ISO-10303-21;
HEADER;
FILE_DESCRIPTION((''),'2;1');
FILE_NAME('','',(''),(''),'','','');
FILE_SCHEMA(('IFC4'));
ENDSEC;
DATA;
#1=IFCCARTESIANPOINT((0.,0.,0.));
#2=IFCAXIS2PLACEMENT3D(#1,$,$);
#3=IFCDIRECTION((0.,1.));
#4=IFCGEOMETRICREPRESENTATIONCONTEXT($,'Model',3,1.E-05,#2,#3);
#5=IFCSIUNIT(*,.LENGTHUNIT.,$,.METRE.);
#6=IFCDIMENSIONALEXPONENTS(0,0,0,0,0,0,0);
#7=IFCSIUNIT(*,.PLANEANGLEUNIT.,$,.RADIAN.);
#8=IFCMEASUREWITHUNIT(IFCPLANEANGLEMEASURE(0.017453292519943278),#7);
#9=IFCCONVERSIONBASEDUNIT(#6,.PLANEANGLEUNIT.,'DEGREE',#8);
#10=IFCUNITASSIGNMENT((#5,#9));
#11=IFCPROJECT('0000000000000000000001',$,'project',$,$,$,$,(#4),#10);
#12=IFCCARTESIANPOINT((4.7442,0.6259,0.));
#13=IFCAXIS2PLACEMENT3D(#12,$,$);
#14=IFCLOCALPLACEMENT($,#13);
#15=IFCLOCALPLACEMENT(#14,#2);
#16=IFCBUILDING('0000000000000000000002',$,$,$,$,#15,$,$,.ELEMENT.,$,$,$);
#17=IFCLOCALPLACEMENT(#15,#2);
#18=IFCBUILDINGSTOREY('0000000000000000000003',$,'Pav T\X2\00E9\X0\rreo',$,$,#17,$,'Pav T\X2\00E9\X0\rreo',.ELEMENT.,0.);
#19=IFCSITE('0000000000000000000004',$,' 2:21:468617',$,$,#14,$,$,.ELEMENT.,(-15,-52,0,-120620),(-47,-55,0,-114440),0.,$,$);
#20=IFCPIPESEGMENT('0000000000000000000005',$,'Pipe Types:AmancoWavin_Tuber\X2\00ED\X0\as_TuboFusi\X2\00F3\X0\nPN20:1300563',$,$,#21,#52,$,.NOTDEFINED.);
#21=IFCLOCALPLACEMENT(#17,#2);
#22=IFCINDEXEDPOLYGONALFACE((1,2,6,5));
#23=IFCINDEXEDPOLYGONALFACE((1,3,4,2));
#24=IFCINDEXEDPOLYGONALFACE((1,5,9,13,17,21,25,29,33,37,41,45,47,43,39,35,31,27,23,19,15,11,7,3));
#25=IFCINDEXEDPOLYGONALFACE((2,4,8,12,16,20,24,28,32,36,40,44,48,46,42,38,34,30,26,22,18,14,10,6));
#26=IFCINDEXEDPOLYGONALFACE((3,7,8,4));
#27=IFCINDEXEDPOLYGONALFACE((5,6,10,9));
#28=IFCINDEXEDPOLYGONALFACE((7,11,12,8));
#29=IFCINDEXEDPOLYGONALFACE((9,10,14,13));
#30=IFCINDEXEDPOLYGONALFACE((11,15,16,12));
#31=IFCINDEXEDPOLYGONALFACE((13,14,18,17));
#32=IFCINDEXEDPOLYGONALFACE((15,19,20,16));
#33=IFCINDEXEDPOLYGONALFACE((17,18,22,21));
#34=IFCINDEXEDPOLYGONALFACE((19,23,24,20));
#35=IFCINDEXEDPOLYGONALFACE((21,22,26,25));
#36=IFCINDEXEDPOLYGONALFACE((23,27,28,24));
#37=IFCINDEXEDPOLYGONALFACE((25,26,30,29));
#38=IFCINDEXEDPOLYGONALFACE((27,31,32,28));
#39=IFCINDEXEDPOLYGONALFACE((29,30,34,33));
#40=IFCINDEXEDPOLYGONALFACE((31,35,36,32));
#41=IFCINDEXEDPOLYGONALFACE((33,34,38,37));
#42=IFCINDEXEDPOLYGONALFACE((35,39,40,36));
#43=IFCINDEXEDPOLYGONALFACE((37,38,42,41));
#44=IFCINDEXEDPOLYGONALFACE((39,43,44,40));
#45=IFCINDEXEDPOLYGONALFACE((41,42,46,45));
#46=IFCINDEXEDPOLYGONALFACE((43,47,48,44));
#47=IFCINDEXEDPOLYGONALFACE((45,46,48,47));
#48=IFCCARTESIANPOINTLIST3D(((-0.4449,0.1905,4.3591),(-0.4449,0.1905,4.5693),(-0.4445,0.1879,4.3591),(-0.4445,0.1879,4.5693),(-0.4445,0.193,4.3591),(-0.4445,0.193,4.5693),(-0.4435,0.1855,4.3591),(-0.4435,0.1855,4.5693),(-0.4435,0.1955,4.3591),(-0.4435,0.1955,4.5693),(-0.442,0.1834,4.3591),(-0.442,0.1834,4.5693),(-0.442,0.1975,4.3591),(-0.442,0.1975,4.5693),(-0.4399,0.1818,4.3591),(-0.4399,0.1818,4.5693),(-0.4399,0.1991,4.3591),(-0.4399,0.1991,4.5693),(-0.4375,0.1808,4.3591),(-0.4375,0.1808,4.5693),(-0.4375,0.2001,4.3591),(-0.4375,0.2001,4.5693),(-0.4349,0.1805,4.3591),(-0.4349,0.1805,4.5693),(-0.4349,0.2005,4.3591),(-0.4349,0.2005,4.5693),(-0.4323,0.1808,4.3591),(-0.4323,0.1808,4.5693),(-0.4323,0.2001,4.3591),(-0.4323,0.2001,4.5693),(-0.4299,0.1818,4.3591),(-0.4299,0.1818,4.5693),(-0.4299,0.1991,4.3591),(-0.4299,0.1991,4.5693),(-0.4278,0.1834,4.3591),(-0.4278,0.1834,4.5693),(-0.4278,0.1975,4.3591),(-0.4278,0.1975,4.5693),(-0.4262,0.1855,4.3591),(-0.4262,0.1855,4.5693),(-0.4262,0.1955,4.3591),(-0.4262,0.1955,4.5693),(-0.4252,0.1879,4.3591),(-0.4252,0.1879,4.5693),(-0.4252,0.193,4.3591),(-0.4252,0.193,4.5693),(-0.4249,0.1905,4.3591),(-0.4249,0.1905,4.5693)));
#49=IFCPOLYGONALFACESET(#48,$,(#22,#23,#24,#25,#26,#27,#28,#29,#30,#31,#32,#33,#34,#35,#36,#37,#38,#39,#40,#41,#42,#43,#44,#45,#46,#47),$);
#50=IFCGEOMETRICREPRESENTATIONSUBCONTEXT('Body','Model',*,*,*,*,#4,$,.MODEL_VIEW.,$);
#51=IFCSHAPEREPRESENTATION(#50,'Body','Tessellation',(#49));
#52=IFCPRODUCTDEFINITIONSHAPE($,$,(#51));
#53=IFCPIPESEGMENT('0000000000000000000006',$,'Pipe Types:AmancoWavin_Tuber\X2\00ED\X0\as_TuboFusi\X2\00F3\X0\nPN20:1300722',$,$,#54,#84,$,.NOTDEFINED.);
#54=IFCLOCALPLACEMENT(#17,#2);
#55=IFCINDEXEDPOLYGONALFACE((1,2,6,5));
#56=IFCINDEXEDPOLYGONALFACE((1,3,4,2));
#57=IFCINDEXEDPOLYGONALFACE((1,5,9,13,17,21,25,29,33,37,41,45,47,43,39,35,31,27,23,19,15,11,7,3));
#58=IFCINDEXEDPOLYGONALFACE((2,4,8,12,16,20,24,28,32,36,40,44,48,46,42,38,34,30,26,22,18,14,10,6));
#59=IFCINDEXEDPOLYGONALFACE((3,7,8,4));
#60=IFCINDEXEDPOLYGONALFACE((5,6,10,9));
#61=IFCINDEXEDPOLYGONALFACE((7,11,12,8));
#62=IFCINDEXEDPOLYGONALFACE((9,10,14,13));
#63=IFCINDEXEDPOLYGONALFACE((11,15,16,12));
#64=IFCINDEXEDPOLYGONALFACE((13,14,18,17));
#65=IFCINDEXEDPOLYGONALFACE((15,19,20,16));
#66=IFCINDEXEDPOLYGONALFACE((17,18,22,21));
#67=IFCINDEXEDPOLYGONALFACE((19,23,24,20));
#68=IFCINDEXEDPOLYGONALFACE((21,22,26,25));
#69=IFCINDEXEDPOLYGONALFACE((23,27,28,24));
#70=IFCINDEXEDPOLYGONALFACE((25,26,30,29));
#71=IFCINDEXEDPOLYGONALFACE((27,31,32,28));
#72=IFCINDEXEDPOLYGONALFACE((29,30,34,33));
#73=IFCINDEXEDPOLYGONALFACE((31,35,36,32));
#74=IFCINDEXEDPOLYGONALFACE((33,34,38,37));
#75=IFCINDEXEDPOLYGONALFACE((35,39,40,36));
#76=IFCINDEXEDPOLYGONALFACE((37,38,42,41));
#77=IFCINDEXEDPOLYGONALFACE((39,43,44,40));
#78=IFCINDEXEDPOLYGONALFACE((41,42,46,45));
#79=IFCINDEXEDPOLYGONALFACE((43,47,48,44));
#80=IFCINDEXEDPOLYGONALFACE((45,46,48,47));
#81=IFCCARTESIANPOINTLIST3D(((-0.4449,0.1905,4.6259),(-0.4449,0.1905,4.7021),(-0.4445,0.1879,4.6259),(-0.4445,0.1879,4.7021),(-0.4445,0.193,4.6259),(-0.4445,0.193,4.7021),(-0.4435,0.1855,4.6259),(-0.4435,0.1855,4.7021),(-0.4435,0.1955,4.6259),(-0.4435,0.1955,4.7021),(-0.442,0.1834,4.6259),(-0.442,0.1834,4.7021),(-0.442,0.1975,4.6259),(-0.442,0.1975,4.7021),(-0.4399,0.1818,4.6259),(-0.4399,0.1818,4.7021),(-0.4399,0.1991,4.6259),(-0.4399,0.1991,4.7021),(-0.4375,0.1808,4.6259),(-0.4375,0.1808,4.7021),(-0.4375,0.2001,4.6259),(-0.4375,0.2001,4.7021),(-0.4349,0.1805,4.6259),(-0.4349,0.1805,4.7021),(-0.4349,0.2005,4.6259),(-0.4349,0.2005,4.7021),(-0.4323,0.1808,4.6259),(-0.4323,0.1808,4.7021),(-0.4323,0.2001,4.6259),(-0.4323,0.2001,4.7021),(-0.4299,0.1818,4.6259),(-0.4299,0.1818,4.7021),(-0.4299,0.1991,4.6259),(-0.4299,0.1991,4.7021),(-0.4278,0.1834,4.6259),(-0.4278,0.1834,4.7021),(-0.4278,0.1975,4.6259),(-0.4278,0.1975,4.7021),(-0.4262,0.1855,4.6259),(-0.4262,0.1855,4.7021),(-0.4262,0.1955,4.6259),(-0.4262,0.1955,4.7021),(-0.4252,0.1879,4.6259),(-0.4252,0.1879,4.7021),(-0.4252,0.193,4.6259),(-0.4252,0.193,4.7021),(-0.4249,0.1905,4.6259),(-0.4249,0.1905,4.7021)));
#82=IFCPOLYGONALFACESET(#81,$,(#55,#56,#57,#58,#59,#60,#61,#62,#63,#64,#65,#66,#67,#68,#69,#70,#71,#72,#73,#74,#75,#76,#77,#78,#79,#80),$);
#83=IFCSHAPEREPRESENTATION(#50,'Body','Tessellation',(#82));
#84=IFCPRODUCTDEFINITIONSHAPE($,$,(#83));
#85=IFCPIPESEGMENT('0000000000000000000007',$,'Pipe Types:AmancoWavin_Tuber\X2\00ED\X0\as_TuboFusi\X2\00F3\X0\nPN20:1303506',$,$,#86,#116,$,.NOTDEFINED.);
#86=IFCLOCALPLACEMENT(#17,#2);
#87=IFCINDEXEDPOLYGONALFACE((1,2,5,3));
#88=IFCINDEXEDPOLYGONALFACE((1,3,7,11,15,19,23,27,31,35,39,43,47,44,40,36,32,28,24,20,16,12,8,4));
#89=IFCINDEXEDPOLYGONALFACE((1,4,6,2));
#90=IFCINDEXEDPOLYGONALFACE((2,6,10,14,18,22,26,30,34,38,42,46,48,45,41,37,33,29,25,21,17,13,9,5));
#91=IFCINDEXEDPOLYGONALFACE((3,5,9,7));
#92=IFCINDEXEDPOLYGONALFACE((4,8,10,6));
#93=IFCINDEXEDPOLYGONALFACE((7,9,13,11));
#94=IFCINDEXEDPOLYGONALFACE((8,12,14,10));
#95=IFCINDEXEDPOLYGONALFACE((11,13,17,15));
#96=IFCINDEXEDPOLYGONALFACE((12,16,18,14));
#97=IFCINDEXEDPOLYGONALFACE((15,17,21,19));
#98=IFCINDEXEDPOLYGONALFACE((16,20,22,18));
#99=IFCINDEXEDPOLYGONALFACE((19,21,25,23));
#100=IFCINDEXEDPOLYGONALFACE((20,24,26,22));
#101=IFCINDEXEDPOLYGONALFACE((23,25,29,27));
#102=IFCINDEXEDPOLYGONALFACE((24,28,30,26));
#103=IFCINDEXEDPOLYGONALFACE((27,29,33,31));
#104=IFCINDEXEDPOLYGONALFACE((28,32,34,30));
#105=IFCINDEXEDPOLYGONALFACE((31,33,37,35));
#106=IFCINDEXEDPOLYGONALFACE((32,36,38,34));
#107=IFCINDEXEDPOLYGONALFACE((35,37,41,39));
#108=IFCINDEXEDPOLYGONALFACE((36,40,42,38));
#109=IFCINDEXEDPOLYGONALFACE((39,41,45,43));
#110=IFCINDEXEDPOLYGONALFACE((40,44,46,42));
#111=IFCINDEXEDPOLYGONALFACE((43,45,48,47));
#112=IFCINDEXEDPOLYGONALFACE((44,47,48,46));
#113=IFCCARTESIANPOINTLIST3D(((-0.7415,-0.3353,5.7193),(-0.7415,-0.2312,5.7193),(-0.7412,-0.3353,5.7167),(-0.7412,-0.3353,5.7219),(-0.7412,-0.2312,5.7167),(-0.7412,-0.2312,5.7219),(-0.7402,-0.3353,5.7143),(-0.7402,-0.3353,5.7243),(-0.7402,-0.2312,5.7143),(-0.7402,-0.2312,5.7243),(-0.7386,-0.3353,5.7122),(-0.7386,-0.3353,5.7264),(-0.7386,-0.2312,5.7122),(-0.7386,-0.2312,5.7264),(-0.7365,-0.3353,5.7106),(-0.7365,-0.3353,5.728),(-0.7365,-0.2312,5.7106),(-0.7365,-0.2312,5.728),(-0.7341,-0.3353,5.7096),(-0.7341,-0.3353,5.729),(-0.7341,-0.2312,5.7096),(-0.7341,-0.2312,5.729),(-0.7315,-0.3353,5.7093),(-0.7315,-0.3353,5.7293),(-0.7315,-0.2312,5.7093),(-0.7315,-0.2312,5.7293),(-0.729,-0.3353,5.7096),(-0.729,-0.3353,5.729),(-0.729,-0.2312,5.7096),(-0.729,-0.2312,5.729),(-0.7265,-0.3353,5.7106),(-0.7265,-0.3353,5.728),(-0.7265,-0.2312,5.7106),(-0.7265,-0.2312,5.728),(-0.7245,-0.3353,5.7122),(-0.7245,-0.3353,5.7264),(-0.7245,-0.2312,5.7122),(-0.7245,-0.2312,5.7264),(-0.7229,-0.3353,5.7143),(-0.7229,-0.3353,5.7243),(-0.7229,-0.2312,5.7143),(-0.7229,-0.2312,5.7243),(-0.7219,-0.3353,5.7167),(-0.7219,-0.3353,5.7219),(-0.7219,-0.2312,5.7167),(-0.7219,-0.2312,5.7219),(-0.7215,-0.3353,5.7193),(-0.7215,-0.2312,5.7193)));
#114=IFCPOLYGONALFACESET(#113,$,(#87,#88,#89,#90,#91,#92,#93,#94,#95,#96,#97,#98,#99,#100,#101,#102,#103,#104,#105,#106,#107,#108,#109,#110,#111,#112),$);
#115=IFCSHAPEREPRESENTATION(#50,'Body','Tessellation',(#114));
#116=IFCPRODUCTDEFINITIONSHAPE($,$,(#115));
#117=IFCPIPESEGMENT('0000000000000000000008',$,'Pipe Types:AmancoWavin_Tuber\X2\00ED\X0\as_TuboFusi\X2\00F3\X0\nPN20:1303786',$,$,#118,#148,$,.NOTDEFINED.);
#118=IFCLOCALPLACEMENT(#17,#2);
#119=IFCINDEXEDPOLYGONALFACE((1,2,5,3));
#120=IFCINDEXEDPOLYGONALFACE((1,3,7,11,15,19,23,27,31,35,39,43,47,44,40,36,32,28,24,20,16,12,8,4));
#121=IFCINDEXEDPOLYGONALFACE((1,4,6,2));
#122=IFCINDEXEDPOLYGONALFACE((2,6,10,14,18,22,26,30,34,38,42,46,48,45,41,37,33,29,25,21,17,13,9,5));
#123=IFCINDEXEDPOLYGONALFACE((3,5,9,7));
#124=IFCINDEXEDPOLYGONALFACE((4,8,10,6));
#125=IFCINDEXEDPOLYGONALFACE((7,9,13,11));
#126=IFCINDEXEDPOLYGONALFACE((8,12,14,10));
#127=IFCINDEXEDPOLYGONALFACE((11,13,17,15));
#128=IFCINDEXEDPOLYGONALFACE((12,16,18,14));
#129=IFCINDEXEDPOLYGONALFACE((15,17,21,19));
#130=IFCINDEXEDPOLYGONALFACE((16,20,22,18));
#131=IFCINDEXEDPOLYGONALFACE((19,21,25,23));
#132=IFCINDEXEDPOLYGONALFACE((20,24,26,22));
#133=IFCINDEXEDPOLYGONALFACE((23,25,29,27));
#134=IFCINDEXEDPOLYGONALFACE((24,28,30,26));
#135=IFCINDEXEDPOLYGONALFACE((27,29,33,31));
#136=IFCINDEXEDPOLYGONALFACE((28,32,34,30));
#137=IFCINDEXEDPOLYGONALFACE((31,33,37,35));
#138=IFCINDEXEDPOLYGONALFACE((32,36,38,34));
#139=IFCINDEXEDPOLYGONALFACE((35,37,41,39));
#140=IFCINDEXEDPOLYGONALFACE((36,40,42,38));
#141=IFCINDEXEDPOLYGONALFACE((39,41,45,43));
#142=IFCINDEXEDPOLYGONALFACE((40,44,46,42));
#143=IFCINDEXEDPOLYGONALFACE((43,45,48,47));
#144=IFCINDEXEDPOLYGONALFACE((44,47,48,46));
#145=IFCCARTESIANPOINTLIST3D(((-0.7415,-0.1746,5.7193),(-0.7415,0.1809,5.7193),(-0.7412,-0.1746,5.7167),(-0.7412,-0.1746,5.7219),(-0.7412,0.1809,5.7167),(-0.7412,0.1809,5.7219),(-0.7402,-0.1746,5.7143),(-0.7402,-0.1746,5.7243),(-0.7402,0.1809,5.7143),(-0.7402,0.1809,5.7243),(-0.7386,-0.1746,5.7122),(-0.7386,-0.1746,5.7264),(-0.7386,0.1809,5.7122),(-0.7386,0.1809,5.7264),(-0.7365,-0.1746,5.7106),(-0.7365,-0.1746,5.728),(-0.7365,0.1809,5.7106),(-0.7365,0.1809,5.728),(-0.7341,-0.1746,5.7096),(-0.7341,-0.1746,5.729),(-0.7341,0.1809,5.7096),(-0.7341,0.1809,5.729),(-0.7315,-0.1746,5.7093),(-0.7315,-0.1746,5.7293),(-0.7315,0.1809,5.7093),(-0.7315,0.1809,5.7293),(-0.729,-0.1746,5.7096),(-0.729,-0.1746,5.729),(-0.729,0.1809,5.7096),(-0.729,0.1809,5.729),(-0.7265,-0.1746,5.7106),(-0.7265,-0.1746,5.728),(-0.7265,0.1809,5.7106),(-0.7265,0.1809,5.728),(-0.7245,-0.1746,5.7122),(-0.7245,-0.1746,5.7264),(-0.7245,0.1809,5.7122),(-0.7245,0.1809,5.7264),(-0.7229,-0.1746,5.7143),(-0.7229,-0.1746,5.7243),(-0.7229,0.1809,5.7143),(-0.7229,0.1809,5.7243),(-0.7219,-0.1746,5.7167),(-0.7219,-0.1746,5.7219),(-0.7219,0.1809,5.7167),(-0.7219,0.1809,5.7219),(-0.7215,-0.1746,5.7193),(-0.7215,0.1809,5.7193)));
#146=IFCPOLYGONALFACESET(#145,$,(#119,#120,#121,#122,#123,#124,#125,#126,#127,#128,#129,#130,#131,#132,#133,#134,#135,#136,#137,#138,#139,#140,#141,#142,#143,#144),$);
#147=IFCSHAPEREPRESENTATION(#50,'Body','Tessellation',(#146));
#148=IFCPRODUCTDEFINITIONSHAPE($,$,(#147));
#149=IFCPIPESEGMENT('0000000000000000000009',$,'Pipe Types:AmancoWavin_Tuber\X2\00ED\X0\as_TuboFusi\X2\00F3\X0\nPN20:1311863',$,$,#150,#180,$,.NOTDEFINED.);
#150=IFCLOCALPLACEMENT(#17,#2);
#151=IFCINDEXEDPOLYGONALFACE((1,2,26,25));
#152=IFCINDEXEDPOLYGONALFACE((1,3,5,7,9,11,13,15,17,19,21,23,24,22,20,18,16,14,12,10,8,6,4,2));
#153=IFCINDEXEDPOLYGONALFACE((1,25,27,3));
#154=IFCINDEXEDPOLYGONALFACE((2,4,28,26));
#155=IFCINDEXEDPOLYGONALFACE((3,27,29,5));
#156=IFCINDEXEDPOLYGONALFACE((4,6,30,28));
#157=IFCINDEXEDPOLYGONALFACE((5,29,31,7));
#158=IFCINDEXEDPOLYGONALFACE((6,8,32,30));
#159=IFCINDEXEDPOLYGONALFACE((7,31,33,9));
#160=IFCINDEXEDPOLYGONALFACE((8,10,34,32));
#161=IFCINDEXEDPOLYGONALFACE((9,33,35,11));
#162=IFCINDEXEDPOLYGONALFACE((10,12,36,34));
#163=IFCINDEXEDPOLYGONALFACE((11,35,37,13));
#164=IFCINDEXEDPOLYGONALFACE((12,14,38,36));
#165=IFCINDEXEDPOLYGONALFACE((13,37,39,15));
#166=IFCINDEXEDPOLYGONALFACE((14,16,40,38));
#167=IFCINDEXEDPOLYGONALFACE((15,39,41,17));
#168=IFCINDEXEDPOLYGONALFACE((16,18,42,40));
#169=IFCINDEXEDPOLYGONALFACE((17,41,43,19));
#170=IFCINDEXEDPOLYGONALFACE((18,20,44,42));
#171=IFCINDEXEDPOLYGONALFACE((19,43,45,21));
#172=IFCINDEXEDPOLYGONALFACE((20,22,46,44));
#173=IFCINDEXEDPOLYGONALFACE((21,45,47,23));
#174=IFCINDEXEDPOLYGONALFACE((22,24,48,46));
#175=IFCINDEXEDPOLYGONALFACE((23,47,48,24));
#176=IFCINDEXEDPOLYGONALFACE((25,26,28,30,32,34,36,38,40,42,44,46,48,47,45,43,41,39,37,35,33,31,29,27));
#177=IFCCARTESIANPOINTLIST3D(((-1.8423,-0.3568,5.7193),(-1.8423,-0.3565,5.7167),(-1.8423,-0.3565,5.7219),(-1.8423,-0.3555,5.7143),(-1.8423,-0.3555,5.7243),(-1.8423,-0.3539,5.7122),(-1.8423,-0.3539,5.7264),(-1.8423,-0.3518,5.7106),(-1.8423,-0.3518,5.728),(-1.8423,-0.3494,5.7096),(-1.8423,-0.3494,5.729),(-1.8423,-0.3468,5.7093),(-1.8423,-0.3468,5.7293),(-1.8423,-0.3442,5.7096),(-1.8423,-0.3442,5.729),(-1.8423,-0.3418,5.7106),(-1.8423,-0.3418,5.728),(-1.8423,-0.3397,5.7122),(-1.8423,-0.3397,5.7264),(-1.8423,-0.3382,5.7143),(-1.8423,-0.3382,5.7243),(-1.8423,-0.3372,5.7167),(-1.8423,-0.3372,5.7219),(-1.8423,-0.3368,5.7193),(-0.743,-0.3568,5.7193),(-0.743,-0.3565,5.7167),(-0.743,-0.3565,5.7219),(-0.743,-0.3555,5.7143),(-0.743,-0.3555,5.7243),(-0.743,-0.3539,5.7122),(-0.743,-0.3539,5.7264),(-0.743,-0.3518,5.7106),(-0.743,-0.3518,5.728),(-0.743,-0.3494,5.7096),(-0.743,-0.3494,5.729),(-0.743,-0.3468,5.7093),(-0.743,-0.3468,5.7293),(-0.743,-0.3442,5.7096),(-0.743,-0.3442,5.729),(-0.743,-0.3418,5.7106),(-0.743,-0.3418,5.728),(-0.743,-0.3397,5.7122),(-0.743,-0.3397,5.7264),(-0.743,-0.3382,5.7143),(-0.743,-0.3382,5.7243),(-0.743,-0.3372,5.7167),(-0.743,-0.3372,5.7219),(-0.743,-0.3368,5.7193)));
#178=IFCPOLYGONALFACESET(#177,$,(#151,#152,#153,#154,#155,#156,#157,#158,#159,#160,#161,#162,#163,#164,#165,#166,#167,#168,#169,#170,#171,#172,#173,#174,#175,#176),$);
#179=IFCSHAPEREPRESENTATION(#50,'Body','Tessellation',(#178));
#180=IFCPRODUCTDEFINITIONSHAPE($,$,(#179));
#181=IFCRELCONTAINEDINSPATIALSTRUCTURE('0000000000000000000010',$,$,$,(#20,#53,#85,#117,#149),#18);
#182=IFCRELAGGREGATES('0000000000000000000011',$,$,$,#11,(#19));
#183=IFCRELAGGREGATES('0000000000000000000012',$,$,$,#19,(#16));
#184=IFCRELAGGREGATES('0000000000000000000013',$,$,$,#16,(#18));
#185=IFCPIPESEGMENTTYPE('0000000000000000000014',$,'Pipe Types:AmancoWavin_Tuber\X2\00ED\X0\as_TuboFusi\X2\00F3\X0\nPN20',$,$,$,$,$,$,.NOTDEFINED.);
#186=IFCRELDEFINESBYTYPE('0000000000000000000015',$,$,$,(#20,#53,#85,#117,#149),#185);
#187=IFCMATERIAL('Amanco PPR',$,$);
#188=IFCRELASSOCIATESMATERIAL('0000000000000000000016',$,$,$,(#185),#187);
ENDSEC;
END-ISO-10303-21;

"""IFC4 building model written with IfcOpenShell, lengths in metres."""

from ifc_helpers import new_model, entity, si_unit, converted_unit, direction, frame, origin, place, context, subcontext, project, spatial, arc, indexed_curve, outline, extrude, material, type_object, element, save


model = new_model("IFC4")

# Units and contexts
model_context = context("Model", 3, precision=1e-05, world=origin(), true_north=direction((0.0, 1.0)))
body_context = subcontext(model_context, "Body", "Model", "MODEL_VIEW")
ifc_project = project(units=[si_unit("LENGTHUNIT", "METRE"), converted_unit("PLANEANGLEUNIT", "DEGREE", entity("IfcPlaneAngleMeasure", 0.017453292519943278), si_unit("PLANEANGLEUNIT", "RADIAN"), dimensions=[0, 0, 0, 0, 0, 0, 0])], contexts=[model_context])

# Site, building, storey
site_placement = place(None, frame((4.7442, 0.6259, 0.0)))
site = spatial("IfcSite", under=ifc_project, at=site_placement, Name=" 2:21:468617", CompositionType="ELEMENT", RefLatitude=(-15, -52, 0, -120620), RefLongitude=(-47, -55, 0, -114440), RefElevation=0.0)
building_placement = place(site_placement, origin())
building = spatial("IfcBuilding", under=site, at=building_placement, CompositionType="ELEMENT")
storey_placement = place(building_placement, origin())
storey = spatial("IfcBuildingStorey", under=building, at=storey_placement, Name="Pav Térreo", LongName="Pav Térreo", CompositionType="ELEMENT", Elevation=0.0)

# Pipe segments
ifc_material_1 = material(Name="Amanco PPR")
pipe_segment_type_1 = type_object("IfcPipeSegmentType", Name="Pipe Types:AmancoWavin_Tuberías_TuboFusiónPN20", PredefinedType="NOTDEFINED", material=ifc_material_1)
pipe_segment_1_placement = place(storey_placement, origin())
element("IfcPipeSegment", 1, at=pipe_segment_1_placement, inside=storey, type_object=pipe_segment_type_1, Name="Pipe Types:AmancoWavin_Tuberías_TuboFusiónPN20:1300563", PredefinedType="NOTDEFINED", context=body_context, shape_type="SweptSolid", body=[
    extrude(outline(indexed_curve([(0.01, 0.0), (0.0071, 0.0071), (0.0, 0.01), (-0.0071, 0.0071), (-0.01, 0.0), (-0.0071, -0.0071), (0.0, -0.01), (0.0071, -0.0071)], segments=[arc(1, 2, 3), arc(3, 4, 5), arc(5, 6, 7), arc(7, 8, 1)], self_intersect=False)), frame((-0.4349, 0.1905, 4.3591)), (0.0, 0.0, 1.0), 0.2102),
])
pipe_segment_2_placement = place(storey_placement, origin())
element("IfcPipeSegment", 2, at=pipe_segment_2_placement, inside=storey, type_object=pipe_segment_type_1, Name="Pipe Types:AmancoWavin_Tuberías_TuboFusiónPN20:1300722", PredefinedType="NOTDEFINED", context=body_context, shape_type="SweptSolid", body=[
    extrude(outline(indexed_curve([(0.01, 0.0), (0.0071, 0.0071), (0.0, 0.01), (-0.0071, 0.0071), (-0.01, 0.0), (-0.0071, -0.0071), (0.0, -0.01), (0.0071, -0.0071)], segments=[arc(1, 2, 3), arc(3, 4, 5), arc(5, 6, 7), arc(7, 8, 1)], self_intersect=False)), frame((-0.4349, 0.1905, 4.6259)), (0.0, 0.0, 1.0), 0.0762),
])
pipe_segment_3_placement = place(storey_placement, origin())
element("IfcPipeSegment", 3, at=pipe_segment_3_placement, inside=storey, type_object=pipe_segment_type_1, Name="Pipe Types:AmancoWavin_Tuberías_TuboFusiónPN20:1303506", PredefinedType="NOTDEFINED", context=body_context, shape_type="SweptSolid", body=[
    extrude(outline(indexed_curve([(0.01, 0.0), (0.0071, 0.0071), (0.0, 0.01), (-0.0071, 0.0071), (-0.01, 0.0), (-0.0071, -0.0071), (0.0, -0.01), (0.0071, -0.0071)], segments=[arc(1, 2, 3), arc(3, 4, 5), arc(5, 6, 7), arc(7, 8, 1)], self_intersect=False)), frame((-0.7315, -0.3353, 5.7193), z_axis=(0.0, 1.0, 0.0), x_axis=(-1.0, 0.0, 0.0)), (0.0, 0.0, 1.0), 0.1041),
])
pipe_segment_4_placement = place(storey_placement, origin())
element("IfcPipeSegment", 4, at=pipe_segment_4_placement, inside=storey, type_object=pipe_segment_type_1, Name="Pipe Types:AmancoWavin_Tuberías_TuboFusiónPN20:1303786", PredefinedType="NOTDEFINED", context=body_context, shape_type="SweptSolid", body=[
    extrude(outline(indexed_curve([(0.01, 0.0), (0.0071, 0.0071), (0.0, 0.01), (-0.0071, 0.0071), (-0.01, 0.0), (-0.0071, -0.0071), (0.0, -0.01), (0.0071, -0.0071)], segments=[arc(1, 2, 3), arc(3, 4, 5), arc(5, 6, 7), arc(7, 8, 1)], self_intersect=False)), frame((-0.7315, -0.1746, 5.7193), z_axis=(0.0, 1.0, 0.0), x_axis=(-1.0, 0.0, 0.0)), (0.0, 0.0, 1.0), 0.3555),
])
pipe_segment_5_placement = place(storey_placement, origin())
element("IfcPipeSegment", 5, at=pipe_segment_5_placement, inside=storey, type_object=pipe_segment_type_1, Name="Pipe Types:AmancoWavin_Tuberías_TuboFusiónPN20:1311863", PredefinedType="NOTDEFINED", context=body_context, shape_type="SweptSolid", body=[
    extrude(outline(indexed_curve([(0.01, 0.0), (0.0071, 0.0071), (0.0, 0.01), (-0.0071, 0.0071), (-0.01, 0.0), (-0.0071, -0.0071), (0.0, -0.01), (0.0071, -0.0071)], segments=[arc(1, 2, 3), arc(3, 4, 5), arc(5, 6, 7), arc(7, 8, 1)], self_intersect=False)), frame((-1.8423, -0.3468, 5.7193), z_axis=(1.0, 0.0, 0.0), x_axis=(0.0, -1.0, 0.0)), (0.0, 0.0, 1.0), 1.0992),
])

save(model, "model.ifc")
